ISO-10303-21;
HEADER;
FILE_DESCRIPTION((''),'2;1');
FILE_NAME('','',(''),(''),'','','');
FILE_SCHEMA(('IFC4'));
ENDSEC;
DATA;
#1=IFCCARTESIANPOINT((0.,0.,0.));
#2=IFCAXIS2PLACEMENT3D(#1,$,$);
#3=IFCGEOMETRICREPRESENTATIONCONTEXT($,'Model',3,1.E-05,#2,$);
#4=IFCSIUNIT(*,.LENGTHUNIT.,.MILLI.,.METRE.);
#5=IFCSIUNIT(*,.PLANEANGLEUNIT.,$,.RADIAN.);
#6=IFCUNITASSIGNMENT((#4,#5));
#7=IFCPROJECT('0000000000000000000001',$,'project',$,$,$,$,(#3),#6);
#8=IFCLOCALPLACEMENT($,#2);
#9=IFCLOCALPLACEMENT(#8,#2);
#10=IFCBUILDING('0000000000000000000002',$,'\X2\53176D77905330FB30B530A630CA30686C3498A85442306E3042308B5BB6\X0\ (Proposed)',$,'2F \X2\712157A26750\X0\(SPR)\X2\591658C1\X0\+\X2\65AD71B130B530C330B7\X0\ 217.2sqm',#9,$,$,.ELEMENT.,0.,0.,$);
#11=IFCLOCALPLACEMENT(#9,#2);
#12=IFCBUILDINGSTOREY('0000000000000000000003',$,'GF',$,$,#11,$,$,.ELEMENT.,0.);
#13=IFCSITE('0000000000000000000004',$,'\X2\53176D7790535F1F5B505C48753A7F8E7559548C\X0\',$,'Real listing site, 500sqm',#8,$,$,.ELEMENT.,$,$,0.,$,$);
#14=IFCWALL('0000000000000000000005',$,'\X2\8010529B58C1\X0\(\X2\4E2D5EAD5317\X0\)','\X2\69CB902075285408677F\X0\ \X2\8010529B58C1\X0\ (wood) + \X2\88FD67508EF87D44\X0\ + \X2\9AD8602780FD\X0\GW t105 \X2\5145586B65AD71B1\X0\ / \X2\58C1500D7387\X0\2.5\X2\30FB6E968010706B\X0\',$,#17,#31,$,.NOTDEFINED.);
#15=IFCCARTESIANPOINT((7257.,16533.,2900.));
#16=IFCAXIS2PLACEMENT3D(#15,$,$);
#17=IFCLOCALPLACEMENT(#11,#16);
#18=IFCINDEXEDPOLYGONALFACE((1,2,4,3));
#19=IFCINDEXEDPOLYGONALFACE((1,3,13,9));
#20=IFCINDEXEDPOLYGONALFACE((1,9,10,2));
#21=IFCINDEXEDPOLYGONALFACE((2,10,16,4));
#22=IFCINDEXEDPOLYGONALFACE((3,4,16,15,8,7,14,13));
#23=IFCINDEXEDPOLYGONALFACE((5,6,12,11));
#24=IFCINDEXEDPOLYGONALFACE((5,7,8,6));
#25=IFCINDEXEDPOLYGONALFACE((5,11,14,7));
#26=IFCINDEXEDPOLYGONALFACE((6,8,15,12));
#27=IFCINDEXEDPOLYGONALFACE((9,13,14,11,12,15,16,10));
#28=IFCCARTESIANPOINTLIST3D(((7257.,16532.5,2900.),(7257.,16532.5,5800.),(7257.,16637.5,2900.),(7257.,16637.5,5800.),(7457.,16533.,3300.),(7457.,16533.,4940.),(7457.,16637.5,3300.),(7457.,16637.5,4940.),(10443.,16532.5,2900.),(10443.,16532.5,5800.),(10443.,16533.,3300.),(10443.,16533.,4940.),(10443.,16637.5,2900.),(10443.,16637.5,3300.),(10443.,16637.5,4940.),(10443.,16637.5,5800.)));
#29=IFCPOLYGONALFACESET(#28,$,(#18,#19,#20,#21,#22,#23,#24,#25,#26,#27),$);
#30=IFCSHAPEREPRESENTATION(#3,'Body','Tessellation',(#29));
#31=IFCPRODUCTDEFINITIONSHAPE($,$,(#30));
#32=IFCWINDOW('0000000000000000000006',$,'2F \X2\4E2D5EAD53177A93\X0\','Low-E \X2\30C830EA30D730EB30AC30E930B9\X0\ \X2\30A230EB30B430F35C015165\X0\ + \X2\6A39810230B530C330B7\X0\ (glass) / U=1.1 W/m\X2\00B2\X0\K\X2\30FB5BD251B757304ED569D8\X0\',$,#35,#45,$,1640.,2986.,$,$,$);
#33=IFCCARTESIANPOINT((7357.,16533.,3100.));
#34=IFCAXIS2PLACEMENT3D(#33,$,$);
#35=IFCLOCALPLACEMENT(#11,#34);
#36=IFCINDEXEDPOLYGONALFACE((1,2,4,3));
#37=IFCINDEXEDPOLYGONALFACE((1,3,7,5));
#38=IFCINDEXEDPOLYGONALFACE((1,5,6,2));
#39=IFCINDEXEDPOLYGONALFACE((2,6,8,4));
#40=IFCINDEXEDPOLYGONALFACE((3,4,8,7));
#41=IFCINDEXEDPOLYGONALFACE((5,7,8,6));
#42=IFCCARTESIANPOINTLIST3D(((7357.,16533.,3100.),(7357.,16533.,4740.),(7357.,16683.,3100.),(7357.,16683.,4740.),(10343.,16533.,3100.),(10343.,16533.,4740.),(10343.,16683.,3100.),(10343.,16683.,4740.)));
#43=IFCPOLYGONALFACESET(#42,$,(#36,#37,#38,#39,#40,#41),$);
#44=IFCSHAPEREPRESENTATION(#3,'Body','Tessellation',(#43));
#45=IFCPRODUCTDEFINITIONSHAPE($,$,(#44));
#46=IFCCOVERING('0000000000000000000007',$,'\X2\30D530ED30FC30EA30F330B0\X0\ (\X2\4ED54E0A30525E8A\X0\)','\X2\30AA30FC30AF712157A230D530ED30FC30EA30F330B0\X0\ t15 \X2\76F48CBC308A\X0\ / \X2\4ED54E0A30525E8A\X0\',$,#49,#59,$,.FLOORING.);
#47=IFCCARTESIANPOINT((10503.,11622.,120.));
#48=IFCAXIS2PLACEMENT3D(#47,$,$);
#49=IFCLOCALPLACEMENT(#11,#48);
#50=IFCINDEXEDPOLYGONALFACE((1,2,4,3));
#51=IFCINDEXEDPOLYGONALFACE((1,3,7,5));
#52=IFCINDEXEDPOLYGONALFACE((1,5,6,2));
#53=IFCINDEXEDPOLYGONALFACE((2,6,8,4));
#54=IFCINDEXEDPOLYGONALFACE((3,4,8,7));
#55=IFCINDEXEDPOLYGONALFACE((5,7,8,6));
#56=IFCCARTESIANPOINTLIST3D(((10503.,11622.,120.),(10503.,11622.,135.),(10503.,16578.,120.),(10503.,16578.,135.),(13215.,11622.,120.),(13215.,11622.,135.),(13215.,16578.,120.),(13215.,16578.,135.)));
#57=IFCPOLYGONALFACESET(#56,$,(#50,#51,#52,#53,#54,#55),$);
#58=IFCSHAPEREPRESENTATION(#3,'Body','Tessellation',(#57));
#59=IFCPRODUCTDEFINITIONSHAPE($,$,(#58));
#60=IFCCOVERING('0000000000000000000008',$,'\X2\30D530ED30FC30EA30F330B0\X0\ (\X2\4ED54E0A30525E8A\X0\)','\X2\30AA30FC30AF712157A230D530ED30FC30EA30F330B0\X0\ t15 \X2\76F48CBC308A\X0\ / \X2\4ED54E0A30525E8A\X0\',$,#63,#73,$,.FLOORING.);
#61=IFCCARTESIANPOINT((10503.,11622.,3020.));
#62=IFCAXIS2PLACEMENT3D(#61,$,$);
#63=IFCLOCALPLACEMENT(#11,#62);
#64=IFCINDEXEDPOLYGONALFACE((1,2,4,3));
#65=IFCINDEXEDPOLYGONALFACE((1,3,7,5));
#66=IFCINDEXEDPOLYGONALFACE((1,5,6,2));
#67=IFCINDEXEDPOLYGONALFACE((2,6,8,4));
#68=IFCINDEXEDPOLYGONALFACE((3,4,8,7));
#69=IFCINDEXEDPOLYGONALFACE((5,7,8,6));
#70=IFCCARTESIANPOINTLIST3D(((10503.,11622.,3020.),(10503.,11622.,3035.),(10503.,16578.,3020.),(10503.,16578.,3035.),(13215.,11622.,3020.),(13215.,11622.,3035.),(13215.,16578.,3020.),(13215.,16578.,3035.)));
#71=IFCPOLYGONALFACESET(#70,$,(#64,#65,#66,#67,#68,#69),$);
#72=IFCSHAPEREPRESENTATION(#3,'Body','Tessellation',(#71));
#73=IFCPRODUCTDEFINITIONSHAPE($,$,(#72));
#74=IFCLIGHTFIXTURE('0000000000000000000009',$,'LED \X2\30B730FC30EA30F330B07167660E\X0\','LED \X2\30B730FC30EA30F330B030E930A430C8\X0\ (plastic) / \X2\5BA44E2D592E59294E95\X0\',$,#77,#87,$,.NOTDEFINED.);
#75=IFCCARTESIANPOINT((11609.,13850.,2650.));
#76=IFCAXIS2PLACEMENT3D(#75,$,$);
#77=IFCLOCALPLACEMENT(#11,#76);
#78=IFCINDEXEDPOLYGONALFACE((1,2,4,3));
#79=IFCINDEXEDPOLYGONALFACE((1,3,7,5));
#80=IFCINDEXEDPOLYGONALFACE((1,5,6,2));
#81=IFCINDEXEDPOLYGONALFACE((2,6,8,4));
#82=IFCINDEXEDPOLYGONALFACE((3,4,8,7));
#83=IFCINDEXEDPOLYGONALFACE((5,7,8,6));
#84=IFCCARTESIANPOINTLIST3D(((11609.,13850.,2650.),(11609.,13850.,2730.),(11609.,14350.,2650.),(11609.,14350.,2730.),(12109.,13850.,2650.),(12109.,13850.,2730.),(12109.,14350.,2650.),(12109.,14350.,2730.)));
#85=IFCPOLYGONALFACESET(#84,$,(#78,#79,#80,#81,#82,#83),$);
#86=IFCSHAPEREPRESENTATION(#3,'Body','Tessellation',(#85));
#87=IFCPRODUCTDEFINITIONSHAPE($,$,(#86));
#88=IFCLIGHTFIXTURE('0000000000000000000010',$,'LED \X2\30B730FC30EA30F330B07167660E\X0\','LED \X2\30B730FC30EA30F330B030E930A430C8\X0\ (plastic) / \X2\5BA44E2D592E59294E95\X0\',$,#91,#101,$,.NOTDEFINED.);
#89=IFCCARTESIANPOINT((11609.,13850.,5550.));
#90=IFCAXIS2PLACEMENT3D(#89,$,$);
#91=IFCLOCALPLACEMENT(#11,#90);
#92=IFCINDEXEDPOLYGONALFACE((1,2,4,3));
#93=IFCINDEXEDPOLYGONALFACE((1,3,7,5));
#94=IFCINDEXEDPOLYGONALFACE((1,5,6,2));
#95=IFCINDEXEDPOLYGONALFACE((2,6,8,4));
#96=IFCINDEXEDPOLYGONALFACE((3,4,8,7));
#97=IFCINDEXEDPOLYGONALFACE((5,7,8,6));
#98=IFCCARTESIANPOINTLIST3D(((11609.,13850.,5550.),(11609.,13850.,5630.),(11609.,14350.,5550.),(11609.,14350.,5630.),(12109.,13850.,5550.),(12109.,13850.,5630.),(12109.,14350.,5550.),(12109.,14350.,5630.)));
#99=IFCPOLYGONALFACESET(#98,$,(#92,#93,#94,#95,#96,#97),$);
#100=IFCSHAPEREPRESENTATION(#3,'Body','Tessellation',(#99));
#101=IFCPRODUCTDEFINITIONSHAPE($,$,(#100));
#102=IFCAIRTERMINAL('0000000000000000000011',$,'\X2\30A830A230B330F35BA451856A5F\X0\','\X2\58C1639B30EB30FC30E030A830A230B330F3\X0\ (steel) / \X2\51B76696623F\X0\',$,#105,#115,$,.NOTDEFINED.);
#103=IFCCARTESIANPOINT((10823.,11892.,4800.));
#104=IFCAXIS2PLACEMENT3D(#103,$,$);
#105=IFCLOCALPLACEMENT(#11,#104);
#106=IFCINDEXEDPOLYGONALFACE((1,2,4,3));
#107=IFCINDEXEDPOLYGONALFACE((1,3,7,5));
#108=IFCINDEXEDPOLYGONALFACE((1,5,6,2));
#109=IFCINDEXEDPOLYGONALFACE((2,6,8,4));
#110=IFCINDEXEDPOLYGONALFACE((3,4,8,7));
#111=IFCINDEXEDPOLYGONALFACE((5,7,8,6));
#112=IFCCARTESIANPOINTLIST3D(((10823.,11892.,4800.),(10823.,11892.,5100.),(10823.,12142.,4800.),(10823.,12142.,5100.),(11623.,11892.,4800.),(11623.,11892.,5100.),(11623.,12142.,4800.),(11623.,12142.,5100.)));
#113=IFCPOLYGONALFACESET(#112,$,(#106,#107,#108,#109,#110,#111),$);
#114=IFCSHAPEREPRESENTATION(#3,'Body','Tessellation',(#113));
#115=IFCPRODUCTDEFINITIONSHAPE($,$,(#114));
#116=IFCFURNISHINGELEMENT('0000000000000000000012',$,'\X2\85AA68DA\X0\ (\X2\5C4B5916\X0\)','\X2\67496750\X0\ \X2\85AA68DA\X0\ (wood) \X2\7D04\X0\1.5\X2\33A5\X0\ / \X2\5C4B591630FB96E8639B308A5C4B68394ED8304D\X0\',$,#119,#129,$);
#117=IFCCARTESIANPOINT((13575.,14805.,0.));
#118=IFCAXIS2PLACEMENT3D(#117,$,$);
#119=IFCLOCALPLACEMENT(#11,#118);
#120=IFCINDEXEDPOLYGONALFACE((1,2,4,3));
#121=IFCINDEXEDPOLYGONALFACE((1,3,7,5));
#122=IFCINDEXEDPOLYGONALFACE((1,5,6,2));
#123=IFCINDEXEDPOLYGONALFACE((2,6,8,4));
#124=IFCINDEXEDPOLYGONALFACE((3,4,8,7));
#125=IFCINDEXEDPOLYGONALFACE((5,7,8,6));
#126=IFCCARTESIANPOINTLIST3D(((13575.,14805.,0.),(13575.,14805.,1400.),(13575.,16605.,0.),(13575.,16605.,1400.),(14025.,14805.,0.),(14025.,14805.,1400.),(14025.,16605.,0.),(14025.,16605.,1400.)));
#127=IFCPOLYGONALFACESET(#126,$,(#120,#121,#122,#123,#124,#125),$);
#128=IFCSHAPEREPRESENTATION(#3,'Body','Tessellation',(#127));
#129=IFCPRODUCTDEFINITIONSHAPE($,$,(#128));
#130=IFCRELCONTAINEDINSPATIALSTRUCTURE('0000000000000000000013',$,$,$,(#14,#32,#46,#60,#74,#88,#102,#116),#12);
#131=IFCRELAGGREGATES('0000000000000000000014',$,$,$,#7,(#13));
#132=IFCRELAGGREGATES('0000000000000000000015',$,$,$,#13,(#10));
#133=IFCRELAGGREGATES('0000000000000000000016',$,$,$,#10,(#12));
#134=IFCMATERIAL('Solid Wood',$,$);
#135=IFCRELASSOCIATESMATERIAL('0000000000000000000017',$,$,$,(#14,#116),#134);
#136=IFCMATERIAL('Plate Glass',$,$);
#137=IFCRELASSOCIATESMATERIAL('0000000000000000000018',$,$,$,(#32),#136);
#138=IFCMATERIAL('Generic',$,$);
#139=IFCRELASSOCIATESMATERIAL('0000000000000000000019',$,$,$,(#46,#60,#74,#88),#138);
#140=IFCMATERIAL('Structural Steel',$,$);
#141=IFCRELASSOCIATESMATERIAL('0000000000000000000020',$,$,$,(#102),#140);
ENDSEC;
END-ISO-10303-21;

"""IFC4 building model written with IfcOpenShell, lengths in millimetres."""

from ifc_helpers import new_model, si_unit, frame, frame_2d, origin, place, context, project, spatial, rectangle, extrude, material, element, fill, save


model = new_model("IFC4")

# Units and contexts
model_context = context("Model", 3, precision=1e-05, world=origin())
ifc_project = project(units=[si_unit("LENGTHUNIT", "METRE", prefix="MILLI"), si_unit("PLANEANGLEUNIT", "RADIAN")], contexts=[model_context])

# Site, building, storey
site_placement = place(None, origin())
site = spatial("IfcSite", under=ifc_project, at=site_placement, Name="北海道弟子屈町美留和", ObjectType="Real listing site, 500sqm", CompositionType="ELEMENT", RefElevation=0.0)
building_placement = place(site_placement, origin())
building = spatial("IfcBuilding", under=site, at=building_placement, Name="北海道・サウナと水風呂のある家 (Proposed)", ObjectType="2F 無垢材(SPR)外壁+断熱サッシ 217.2sqm", CompositionType="ELEMENT", ElevationOfRefHeight=0.0, ElevationOfTerrain=0.0)
storey_placement = place(building_placement, origin())
storey = spatial("IfcBuildingStorey", under=building, at=storey_placement, Name="GF", CompositionType="ELEMENT", Elevation=0.0)

# Shared definitions
ifc_material_1 = material(Name="Solid Wood")

# Wall, opening, window
ifc_material_2 = material(Name="Plate Glass")
wall_1_placement = place(storey_placement, frame((7257.0, 16533.0, 2900.0)))
wall_1 = element("IfcWall", 1, at=wall_1_placement, inside=storey, material=ifc_material_1, Name="耐力壁(中庭北)", Description="構造用合板 耐力壁 (wood) + 製材軸組 + 高性能GW t105 充填断熱 / 壁倍率2.5・準耐火", PredefinedType="NOTDEFINED", context=model_context, shape_type="SweptSolid", body=[
    extrude(rectangle(XDim=3186.0, YDim=105.0, at=frame_2d((1593.0, 52.0))), frame((7257.0, 16533.0, 2900.0)), (0.0, 0.0, 1.0), 2900.0),
])
opening_1_placement = place(storey_placement, frame((7357.0, 16533.0, 3100.0)))
opening_1 = element("IfcOpeningElement", 2, at=opening_1_placement, cuts=wall_1, PredefinedType="NOTDEFINED", context=model_context, shape_type="SweptSolid", body=[
    extrude(rectangle(XDim=2986.0, YDim=150.0, at=frame_2d((1493.0, 75.0))), frame((7357.0, 16533.0, 3100.0)), (0.0, 0.0, 1.0), 1640.0),
])
window_1_placement = place(storey_placement, frame((7357.0, 16533.0, 3100.0)))
window_1 = element("IfcWindow", 3, at=window_1_placement, inside=storey, material=ifc_material_2, Name="2F 中庭北窓", Description="Low-E トリプルガラス アルゴン封入 + 樹脂サッシ (glass) / U=1.1 W/m²K・寒冷地仕様", OverallHeight=1640.0, OverallWidth=2986.0, context=model_context, shape_type="SweptSolid", body=[
    extrude(rectangle(XDim=2986.0, YDim=150.0, at=frame_2d((1493.0, 75.0))), frame((7357.0, 16533.0, 3100.0)), (0.0, 0.0, 1.0), 1640.0),
])
fill(opening_1, window_1)

# Coverings
ifc_material_3 = material(Name="Generic")
covering_1_placement = place(storey_placement, frame((10503.0, 11622.0, 120.0)))
element("IfcCovering", 4, at=covering_1_placement, inside=storey, material=ifc_material_3, Name="フローリング (仕上げ床)", Description="オーク無垢フローリング t15 直貼り / 仕上げ床", PredefinedType="FLOORING", context=model_context, shape_type="SweptSolid", body=[
    extrude(rectangle(XDim=2712.0, YDim=4956.0, at=frame_2d((1356.0, 2478.0))), frame((10503.0, 11622.0, 120.0)), (0.0, 0.0, 1.0), 15.0),
])
covering_2_placement = place(storey_placement, frame((10503.0, 11622.0, 3020.0)))
element("IfcCovering", 5, at=covering_2_placement, inside=storey, material=ifc_material_3, Name="フローリング (仕上げ床)", Description="オーク無垢フローリング t15 直貼り / 仕上げ床", PredefinedType="FLOORING", context=model_context, shape_type="SweptSolid", body=[
    extrude(rectangle(XDim=2712.0, YDim=4956.0, at=frame_2d((1356.0, 2478.0))), frame((10503.0, 11622.0, 3020.0)), (0.0, 0.0, 1.0), 15.0),
])

# Light fixtures
light_fixture_1_placement = place(storey_placement, frame((11609.0, 13850.0, 2650.0)))
element("IfcLightFixture", 6, at=light_fixture_1_placement, inside=storey, material=ifc_material_3, Name="LED シーリング照明", Description="LED シーリングライト (plastic) / 室中央天井", PredefinedType="NOTDEFINED", context=model_context, shape_type="SweptSolid", body=[
    extrude(rectangle(XDim=500.0, YDim=500.0, at=frame_2d((250.0, 250.0))), frame((11609.0, 13850.0, 2650.0)), (0.0, 0.0, 1.0), 80.0),
])
light_fixture_2_placement = place(storey_placement, frame((11609.0, 13850.0, 5550.0)))
element("IfcLightFixture", 7, at=light_fixture_2_placement, inside=storey, material=ifc_material_3, Name="LED シーリング照明", Description="LED シーリングライト (plastic) / 室中央天井", PredefinedType="NOTDEFINED", context=model_context, shape_type="SweptSolid", body=[
    extrude(rectangle(XDim=500.0, YDim=500.0, at=frame_2d((250.0, 250.0))), frame((11609.0, 13850.0, 5550.0)), (0.0, 0.0, 1.0), 80.0),
])

# Air terminal
ifc_material_4 = material(Name="Structural Steel")
air_terminal_placement = place(storey_placement, frame((10823.0, 11892.0, 4800.0)))
element("IfcAirTerminal", 8, at=air_terminal_placement, inside=storey, material=ifc_material_4, Name="エアコン室内機", Description="壁掛ルームエアコン (steel) / 冷暖房", PredefinedType="NOTDEFINED", context=model_context, shape_type="SweptSolid", body=[
    extrude(rectangle(XDim=800.0, YDim=250.0, at=frame_2d((400.0, 125.0))), frame((10823.0, 11892.0, 4800.0)), (0.0, 0.0, 1.0), 300.0),
])

# Furnishing element
furnishing_placement = place(storey_placement, frame((13575.0, 14805.0, 0.0)))
element("IfcFurnishingElement", 9, at=furnishing_placement, inside=storey, material=ifc_material_1, Name="薪棚 (屋外)", Description="杉材 薪棚 (wood) 約1.5㎥ / 屋外・雨掛り屋根付き", context=model_context, shape_type="SweptSolid", body=[
    extrude(rectangle(XDim=450.0, YDim=1800.0, at=frame_2d((225.0, 900.0))), frame((13575.0, 14805.0, 0.0)), (0.0, 0.0, 1.0), 1400.0),
])

save(model, "model.ifc")
